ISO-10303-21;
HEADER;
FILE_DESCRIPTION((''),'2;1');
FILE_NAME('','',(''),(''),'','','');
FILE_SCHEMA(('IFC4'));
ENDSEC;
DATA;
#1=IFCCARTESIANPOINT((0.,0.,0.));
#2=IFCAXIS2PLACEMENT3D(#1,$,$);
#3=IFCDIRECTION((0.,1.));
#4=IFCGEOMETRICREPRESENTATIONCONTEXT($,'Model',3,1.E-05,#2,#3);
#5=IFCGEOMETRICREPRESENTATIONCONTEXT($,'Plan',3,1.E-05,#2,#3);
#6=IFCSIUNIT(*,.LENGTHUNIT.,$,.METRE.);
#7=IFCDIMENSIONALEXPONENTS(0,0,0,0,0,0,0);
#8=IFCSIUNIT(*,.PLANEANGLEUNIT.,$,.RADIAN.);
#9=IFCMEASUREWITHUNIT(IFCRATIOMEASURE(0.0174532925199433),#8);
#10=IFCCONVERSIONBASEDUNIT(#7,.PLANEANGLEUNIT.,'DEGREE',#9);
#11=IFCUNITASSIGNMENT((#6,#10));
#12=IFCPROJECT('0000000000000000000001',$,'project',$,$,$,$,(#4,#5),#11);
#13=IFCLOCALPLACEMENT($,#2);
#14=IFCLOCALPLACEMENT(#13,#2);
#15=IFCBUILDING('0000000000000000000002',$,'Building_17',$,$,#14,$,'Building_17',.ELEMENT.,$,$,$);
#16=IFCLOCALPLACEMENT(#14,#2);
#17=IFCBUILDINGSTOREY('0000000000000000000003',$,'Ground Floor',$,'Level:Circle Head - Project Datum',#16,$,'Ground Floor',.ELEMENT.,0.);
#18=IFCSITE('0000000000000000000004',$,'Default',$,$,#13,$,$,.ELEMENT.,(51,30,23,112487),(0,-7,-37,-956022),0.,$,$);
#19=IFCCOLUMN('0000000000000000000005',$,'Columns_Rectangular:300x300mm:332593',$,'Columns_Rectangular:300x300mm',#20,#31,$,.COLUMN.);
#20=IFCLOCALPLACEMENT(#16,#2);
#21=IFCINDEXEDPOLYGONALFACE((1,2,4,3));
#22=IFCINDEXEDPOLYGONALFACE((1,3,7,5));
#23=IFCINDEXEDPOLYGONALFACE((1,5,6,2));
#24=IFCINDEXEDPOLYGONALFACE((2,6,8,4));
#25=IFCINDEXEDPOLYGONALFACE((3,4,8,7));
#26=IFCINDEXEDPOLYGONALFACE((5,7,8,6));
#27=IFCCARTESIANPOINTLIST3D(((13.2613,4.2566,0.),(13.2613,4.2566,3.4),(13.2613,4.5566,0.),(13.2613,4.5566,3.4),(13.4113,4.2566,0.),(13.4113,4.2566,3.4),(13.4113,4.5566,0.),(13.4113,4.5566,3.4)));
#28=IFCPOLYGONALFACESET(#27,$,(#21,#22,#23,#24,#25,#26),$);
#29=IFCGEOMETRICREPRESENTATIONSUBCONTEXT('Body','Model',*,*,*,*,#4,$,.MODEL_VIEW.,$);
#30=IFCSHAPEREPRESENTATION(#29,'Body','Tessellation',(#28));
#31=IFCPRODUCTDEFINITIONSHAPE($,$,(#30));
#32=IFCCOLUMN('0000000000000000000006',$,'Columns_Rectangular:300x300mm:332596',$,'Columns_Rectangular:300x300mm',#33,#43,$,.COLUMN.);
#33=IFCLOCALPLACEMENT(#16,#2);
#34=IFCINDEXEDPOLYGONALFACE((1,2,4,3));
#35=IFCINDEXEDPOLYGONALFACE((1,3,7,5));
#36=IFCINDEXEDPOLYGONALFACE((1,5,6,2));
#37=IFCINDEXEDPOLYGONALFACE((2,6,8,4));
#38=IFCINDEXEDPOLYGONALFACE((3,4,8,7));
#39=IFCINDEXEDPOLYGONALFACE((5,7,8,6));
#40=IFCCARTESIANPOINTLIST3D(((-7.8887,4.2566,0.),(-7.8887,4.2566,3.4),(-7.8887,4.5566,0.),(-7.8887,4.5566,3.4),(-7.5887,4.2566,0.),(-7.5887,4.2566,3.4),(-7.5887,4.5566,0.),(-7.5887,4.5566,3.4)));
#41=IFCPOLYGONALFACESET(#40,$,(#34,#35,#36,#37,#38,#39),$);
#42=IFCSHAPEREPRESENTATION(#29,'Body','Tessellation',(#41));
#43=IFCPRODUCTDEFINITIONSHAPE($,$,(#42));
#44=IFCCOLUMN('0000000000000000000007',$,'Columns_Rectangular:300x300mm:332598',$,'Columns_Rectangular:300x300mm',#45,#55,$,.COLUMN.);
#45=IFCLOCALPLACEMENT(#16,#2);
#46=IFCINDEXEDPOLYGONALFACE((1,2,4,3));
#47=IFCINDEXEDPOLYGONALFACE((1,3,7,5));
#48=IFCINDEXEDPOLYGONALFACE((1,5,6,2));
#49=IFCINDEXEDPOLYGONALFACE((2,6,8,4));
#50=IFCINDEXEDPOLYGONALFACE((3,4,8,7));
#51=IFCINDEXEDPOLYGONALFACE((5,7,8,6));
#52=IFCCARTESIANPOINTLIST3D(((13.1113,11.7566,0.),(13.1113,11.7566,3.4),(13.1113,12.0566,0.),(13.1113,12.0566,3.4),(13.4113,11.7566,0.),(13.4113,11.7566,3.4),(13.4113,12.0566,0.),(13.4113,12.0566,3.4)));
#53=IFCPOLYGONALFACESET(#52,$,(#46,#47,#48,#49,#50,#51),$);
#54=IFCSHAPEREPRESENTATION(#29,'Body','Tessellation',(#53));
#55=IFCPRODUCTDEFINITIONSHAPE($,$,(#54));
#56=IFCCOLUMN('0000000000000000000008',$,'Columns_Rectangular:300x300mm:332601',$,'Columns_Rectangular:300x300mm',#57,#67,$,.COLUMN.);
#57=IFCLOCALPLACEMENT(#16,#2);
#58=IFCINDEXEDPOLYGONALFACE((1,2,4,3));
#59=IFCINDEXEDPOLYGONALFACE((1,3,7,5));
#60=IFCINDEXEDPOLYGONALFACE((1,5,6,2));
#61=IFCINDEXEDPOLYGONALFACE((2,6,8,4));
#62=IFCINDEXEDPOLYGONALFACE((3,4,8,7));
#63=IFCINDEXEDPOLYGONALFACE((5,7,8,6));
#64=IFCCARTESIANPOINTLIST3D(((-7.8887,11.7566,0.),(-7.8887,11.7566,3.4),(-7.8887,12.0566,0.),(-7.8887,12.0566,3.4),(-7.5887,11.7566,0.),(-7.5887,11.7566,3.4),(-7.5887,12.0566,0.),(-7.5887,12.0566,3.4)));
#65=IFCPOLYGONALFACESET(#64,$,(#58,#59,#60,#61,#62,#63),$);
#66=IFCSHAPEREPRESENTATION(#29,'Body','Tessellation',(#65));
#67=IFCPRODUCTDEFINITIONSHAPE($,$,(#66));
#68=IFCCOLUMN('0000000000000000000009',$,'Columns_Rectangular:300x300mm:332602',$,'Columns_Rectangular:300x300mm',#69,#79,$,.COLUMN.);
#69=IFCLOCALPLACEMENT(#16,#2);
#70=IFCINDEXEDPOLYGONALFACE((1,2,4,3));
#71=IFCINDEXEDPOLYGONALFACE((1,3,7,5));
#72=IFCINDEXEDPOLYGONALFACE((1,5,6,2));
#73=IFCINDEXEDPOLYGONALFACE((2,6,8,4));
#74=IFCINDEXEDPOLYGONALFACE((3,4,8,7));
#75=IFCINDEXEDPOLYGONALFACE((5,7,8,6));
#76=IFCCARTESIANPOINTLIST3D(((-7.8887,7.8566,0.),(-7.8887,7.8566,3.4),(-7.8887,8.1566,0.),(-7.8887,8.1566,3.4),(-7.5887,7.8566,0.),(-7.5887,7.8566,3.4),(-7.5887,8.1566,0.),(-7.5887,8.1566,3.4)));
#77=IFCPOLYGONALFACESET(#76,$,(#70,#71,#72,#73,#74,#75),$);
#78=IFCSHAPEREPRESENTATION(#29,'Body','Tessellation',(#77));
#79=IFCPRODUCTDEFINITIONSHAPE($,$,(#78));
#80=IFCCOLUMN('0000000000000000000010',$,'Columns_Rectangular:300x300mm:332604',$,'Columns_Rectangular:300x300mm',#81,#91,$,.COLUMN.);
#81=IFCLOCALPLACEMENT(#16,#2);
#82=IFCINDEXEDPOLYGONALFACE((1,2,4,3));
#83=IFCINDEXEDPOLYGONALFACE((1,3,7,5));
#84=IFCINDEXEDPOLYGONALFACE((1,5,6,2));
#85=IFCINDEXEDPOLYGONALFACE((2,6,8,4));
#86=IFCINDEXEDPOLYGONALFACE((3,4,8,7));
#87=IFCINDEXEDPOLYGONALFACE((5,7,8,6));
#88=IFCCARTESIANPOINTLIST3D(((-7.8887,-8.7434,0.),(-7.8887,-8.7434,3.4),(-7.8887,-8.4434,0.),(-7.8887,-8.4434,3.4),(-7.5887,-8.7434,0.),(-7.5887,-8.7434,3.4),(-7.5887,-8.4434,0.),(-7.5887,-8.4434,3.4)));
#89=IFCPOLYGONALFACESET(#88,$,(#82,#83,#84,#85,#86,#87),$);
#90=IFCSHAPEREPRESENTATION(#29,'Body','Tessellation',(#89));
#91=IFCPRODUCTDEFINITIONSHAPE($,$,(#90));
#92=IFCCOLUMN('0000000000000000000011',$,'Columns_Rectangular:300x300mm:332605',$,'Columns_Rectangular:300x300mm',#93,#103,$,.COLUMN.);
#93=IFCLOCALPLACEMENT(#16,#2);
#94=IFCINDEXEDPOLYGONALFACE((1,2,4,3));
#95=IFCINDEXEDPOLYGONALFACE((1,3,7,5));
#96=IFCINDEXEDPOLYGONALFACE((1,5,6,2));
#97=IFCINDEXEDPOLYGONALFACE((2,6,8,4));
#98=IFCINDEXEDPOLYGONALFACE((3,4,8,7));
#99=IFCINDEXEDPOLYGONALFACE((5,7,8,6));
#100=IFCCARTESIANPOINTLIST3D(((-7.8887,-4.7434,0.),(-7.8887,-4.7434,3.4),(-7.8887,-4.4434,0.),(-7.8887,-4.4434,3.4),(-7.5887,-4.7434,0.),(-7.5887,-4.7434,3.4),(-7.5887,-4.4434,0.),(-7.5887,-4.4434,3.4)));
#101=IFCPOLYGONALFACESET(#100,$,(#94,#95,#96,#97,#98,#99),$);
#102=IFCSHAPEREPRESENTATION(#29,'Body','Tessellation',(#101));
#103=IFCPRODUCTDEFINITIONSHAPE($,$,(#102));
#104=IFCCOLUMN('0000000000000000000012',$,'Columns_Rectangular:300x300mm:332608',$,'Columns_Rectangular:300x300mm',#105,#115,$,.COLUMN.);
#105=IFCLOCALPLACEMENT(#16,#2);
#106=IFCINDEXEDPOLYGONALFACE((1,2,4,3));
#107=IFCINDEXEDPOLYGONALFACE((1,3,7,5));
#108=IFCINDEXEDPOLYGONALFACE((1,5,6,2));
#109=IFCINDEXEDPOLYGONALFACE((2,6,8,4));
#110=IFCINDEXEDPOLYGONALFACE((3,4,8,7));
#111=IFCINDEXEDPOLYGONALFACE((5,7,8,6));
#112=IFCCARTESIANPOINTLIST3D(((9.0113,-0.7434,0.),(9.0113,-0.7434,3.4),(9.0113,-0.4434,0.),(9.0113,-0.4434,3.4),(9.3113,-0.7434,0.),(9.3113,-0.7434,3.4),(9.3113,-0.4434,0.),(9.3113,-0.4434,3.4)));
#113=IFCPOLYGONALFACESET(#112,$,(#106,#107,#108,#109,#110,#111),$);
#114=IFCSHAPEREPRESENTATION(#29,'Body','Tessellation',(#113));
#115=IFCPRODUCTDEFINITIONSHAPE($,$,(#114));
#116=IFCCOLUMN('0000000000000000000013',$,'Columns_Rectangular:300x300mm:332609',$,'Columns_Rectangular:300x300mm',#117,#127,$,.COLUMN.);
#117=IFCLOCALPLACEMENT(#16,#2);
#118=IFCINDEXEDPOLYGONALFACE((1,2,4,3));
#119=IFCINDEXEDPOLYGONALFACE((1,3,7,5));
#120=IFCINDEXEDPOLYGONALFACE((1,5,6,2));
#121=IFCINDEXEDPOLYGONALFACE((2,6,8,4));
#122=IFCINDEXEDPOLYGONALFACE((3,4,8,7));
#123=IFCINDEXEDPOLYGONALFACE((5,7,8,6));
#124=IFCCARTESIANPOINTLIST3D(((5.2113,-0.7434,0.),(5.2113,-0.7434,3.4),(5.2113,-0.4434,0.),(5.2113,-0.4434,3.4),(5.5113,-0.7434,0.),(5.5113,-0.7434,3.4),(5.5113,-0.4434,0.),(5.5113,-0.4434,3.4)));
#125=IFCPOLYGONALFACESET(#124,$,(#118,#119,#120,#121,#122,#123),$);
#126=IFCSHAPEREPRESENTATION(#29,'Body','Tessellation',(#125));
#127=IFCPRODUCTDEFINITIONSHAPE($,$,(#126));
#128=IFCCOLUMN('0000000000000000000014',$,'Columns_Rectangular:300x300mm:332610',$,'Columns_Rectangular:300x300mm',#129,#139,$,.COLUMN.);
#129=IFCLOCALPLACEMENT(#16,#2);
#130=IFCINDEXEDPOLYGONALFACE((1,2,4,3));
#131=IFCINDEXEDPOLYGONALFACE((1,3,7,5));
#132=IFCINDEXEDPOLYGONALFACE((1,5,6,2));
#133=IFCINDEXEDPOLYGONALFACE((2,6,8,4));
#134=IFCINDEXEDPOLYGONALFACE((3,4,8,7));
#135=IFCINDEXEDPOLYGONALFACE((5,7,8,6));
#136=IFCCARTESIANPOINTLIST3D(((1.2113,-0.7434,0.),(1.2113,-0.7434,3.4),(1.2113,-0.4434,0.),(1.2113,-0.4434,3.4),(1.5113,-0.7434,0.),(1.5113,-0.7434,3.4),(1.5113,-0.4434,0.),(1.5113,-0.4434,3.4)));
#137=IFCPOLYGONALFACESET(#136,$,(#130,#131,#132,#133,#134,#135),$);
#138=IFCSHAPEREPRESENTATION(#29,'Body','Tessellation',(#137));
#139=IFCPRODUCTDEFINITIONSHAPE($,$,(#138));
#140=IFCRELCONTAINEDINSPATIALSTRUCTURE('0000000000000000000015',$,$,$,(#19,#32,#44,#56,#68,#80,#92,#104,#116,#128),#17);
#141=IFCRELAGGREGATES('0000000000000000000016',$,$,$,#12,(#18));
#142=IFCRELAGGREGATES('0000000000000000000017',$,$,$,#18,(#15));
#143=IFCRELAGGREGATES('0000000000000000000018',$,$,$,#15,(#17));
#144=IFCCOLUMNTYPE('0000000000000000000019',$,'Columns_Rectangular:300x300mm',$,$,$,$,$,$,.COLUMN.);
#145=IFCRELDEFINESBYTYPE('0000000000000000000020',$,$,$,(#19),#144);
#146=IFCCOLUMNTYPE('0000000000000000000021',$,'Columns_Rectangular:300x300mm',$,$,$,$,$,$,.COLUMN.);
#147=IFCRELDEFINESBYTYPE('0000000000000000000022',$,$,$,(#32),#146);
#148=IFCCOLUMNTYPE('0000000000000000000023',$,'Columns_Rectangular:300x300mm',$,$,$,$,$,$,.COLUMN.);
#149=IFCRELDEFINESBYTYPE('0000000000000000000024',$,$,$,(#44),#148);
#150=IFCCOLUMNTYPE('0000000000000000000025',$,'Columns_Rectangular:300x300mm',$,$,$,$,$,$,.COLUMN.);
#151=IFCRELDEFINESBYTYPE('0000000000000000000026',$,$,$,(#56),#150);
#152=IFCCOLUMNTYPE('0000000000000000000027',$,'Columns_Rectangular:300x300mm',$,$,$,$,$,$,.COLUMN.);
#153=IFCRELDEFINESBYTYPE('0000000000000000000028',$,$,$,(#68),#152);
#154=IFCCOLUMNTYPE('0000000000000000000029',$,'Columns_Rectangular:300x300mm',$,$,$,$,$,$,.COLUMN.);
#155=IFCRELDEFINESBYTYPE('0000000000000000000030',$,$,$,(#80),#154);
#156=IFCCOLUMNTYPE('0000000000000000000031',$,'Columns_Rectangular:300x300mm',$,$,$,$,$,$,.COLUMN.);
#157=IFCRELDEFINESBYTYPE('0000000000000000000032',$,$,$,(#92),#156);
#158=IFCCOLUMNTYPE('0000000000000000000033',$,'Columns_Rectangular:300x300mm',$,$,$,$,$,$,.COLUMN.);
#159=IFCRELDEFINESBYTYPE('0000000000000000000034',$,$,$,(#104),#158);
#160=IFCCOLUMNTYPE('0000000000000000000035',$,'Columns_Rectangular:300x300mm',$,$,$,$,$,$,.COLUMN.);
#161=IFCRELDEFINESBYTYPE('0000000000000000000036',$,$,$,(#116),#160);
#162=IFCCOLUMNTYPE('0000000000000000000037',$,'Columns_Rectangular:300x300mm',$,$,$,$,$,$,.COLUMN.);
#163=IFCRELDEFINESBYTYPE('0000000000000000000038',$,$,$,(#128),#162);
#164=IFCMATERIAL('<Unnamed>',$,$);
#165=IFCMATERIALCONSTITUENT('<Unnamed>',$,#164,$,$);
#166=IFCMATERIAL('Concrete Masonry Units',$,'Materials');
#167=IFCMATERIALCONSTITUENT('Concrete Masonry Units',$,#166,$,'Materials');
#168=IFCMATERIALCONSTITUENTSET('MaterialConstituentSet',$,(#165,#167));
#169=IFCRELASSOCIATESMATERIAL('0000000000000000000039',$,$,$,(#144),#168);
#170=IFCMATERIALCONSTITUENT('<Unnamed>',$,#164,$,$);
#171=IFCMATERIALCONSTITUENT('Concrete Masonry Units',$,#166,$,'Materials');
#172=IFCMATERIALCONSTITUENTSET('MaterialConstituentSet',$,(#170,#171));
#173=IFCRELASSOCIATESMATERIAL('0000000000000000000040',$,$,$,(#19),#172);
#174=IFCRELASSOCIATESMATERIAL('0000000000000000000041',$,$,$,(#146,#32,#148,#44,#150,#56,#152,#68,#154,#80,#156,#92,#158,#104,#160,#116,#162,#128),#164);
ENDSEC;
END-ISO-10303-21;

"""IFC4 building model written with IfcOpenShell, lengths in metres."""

from ifc_helpers import new_model, entity, si_unit, converted_unit, direction, frame, origin, place, context, subcontext, project, spatial, indexed_curve, outline, extrude, source, transform, mapped, material, constituent, constituent_set, type_object, type_shapes, element, save


model = new_model("IFC4")

# Units and contexts
model_context = context("Model", 3, precision=1e-05, world=origin(), true_north=direction((0.0, 1.0)))
plan_context = context("Plan", 3, precision=1e-05, world=origin(), true_north=direction((0.0, 1.0)))
body_context = subcontext(model_context, "Body", "Model", "MODEL_VIEW")
ifc_project = project(units=[si_unit("LENGTHUNIT", "METRE"), converted_unit("PLANEANGLEUNIT", "DEGREE", entity("IfcRatioMeasure", 0.0174532925199433), si_unit("PLANEANGLEUNIT", "RADIAN"), dimensions=[0, 0, 0, 0, 0, 0, 0])], contexts=[model_context, plan_context])

# Site, building, storey
site_placement = place(None, origin())
site = spatial("IfcSite", under=ifc_project, at=site_placement, Name="Default", CompositionType="ELEMENT", RefLatitude=(51, 30, 23, 112487), RefLongitude=(0, -7, -37, -956022), RefElevation=0.0)
building_placement = place(site_placement, origin())
building = spatial("IfcBuilding", under=site, at=building_placement, Name="Building_17", LongName="Building_17", CompositionType="ELEMENT")
storey_placement = place(building_placement, origin())
storey = spatial("IfcBuildingStorey", under=building, at=storey_placement, Name="Ground Floor", ObjectType="Level:Circle Head - Project Datum", LongName="Ground Floor", CompositionType="ELEMENT", Elevation=0.0)

# Columns
ifc_material_1 = material(Name="<Unnamed>")
ifc_constituent_1 = constituent(ifc_material_1, Name="<Unnamed>")
ifc_material_2 = material(Name="Concrete Masonry Units", Category="Materials")
ifc_constituent_2 = constituent(ifc_material_2, Name="Concrete Masonry Units", Category="Materials")
ifc_constituent_set_1 = constituent_set(constituents=[ifc_constituent_1, ifc_constituent_2], Name="MaterialConstituentSet")
ifc_constituent_3 = constituent(ifc_material_1, Name="<Unnamed>")
ifc_constituent_4 = constituent(ifc_material_2, Name="Concrete Masonry Units", Category="Materials")
ifc_constituent_set_2 = constituent_set(constituents=[ifc_constituent_3, ifc_constituent_4], Name="MaterialConstituentSet")
column_type_1 = type_object("IfcColumnType", Name="Columns_Rectangular:300x300mm", PredefinedType="COLUMN", material=ifc_constituent_set_2)
shared_shape_1 = source(origin(), body_context, "Body", "SweptSolid", [
    extrude(outline(indexed_curve([(-0.15, -0.075), (0.15, -0.075), (0.15, 0.075), (-0.15, 0.075), (-0.15, -0.075)], self_intersect=False)), frame((13.3363, 4.4066, 0.0), z_axis=(0.0, 0.0, 1.0), x_axis=(0.0, -1.0, 0.0)), (0.0, 0.0, 1.0), 3.4),
])
type_shapes(column_type_1, [shared_shape_1])
column_1_placement = place(storey_placement, origin())
element("IfcColumn", 1, at=column_1_placement, inside=storey, type_object=column_type_1, material=ifc_constituent_set_1, Name="Columns_Rectangular:300x300mm:332593", ObjectType="Columns_Rectangular:300x300mm", PredefinedType="COLUMN", context=body_context, shape_type="MappedRepresentation", body=[
    mapped(shared_shape_1, transform((0.0, 0.0, 0.0), scale=1.0)),
])
column_type_2 = type_object("IfcColumnType", Name="Columns_Rectangular:300x300mm", PredefinedType="COLUMN", material=ifc_material_1)
shared_shape_2 = source(origin(), body_context, "Body", "SweptSolid", [
    extrude(outline(indexed_curve([(-0.15, -0.15), (0.15, -0.15), (0.15, 0.15), (-0.15, 0.15), (-0.15, -0.15)], self_intersect=False)), frame((-7.7387, 4.4066, 0.0), z_axis=(0.0, 0.0, 1.0), x_axis=(0.0, -1.0, 0.0)), (0.0, 0.0, 1.0), 3.4),
])
type_shapes(column_type_2, [shared_shape_2])
column_2_placement = place(storey_placement, origin())
element("IfcColumn", 2, at=column_2_placement, inside=storey, type_object=column_type_2, material=ifc_material_1, Name="Columns_Rectangular:300x300mm:332596", ObjectType="Columns_Rectangular:300x300mm", PredefinedType="COLUMN", context=body_context, shape_type="MappedRepresentation", body=[
    mapped(shared_shape_2, transform((0.0, 0.0, 0.0), scale=1.0)),
])
column_type_3 = type_object("IfcColumnType", Name="Columns_Rectangular:300x300mm", PredefinedType="COLUMN", material=ifc_material_1)
shared_shape_3 = source(origin(), body_context, "Body", "SweptSolid", [
    extrude(outline(indexed_curve([(-0.15, -0.15), (0.15, -0.15), (0.15, 0.15), (-0.15, 0.15), (-0.15, -0.15)], self_intersect=False)), frame((13.2613, 11.9066, 0.0), z_axis=(0.0, 0.0, 1.0), x_axis=(0.0, -1.0, 0.0)), (0.0, 0.0, 1.0), 3.4),
])
type_shapes(column_type_3, [shared_shape_3])
column_3_placement = place(storey_placement, origin())
element("IfcColumn", 3, at=column_3_placement, inside=storey, type_object=column_type_3, material=ifc_material_1, Name="Columns_Rectangular:300x300mm:332598", ObjectType="Columns_Rectangular:300x300mm", PredefinedType="COLUMN", context=body_context, shape_type="MappedRepresentation", body=[
    mapped(shared_shape_3, transform((0.0, 0.0, 0.0), scale=1.0)),
])
column_type_4 = type_object("IfcColumnType", Name="Columns_Rectangular:300x300mm", PredefinedType="COLUMN", material=ifc_material_1)
shared_shape_4 = source(origin(), body_context, "Body", "SweptSolid", [
    extrude(outline(indexed_curve([(-0.15, -0.15), (0.15, -0.15), (0.15, 0.15), (-0.15, 0.15), (-0.15, -0.15)], self_intersect=False)), frame((-7.7387, 11.9066, 0.0), z_axis=(0.0, 0.0, 1.0), x_axis=(0.0, -1.0, 0.0)), (0.0, 0.0, 1.0), 3.4),
])
type_shapes(column_type_4, [shared_shape_4])
column_4_placement = place(storey_placement, origin())
element("IfcColumn", 4, at=column_4_placement, inside=storey, type_object=column_type_4, material=ifc_material_1, Name="Columns_Rectangular:300x300mm:332601", ObjectType="Columns_Rectangular:300x300mm", PredefinedType="COLUMN", context=body_context, shape_type="MappedRepresentation", body=[
    mapped(shared_shape_4, transform((0.0, 0.0, 0.0), scale=1.0)),
])
column_type_5 = type_object("IfcColumnType", Name="Columns_Rectangular:300x300mm", PredefinedType="COLUMN", material=ifc_material_1)
shared_shape_5 = source(origin(), body_context, "Body", "SweptSolid", [
    extrude(outline(indexed_curve([(-0.15, -0.15), (0.15, -0.15), (0.15, 0.15), (-0.15, 0.15), (-0.15, -0.15)], self_intersect=False)), frame((-7.7387, 8.0066, 0.0), z_axis=(0.0, 0.0, 1.0), x_axis=(0.0, -1.0, 0.0)), (0.0, 0.0, 1.0), 3.4),
])
type_shapes(column_type_5, [shared_shape_5])
column_5_placement = place(storey_placement, origin())
element("IfcColumn", 5, at=column_5_placement, inside=storey, type_object=column_type_5, material=ifc_material_1, Name="Columns_Rectangular:300x300mm:332602", ObjectType="Columns_Rectangular:300x300mm", PredefinedType="COLUMN", context=body_context, shape_type="MappedRepresentation", body=[
    mapped(shared_shape_5, transform((0.0, 0.0, 0.0), scale=1.0)),
])
column_type_6 = type_object("IfcColumnType", Name="Columns_Rectangular:300x300mm", PredefinedType="COLUMN", material=ifc_material_1)
shared_shape_6 = source(origin(), body_context, "Body", "SweptSolid", [
    extrude(outline(indexed_curve([(-0.15, -0.15), (0.15, -0.15), (0.15, 0.15), (-0.15, 0.15), (-0.15, -0.15)], self_intersect=False)), frame((-7.7387, -8.5934, 0.0), z_axis=(0.0, 0.0, 1.0), x_axis=(0.0, -1.0, 0.0)), (0.0, 0.0, 1.0), 3.4),
])
type_shapes(column_type_6, [shared_shape_6])
column_6_placement = place(storey_placement, origin())
element("IfcColumn", 6, at=column_6_placement, inside=storey, type_object=column_type_6, material=ifc_material_1, Name="Columns_Rectangular:300x300mm:332604", ObjectType="Columns_Rectangular:300x300mm", PredefinedType="COLUMN", context=body_context, shape_type="MappedRepresentation", body=[
    mapped(shared_shape_6, transform((0.0, 0.0, 0.0), scale=1.0)),
])
column_type_7 = type_object("IfcColumnType", Name="Columns_Rectangular:300x300mm", PredefinedType="COLUMN", material=ifc_material_1)
shared_shape_7 = source(origin(), body_context, "Body", "SweptSolid", [
    extrude(outline(indexed_curve([(-0.15, -0.15), (0.15, -0.15), (0.15, 0.15), (-0.15, 0.15), (-0.15, -0.15)], self_intersect=False)), frame((-7.7387, -4.5934, 0.0), z_axis=(0.0, 0.0, 1.0), x_axis=(0.0, -1.0, 0.0)), (0.0, 0.0, 1.0), 3.4),
])
type_shapes(column_type_7, [shared_shape_7])
column_7_placement = place(storey_placement, origin())
element("IfcColumn", 7, at=column_7_placement, inside=storey, type_object=column_type_7, material=ifc_material_1, Name="Columns_Rectangular:300x300mm:332605", ObjectType="Columns_Rectangular:300x300mm", PredefinedType="COLUMN", context=body_context, shape_type="MappedRepresentation", body=[
    mapped(shared_shape_7, transform((0.0, 0.0, 0.0), scale=1.0)),
])
column_type_8 = type_object("IfcColumnType", Name="Columns_Rectangular:300x300mm", PredefinedType="COLUMN", material=ifc_material_1)
shared_shape_8 = source(origin(), body_context, "Body", "SweptSolid", [
    extrude(outline(indexed_curve([(-0.15, -0.15), (0.15, -0.15), (0.15, 0.15), (-0.15, 0.15), (-0.15, -0.15)], self_intersect=False)), frame((9.1613, -0.5934, 0.0), z_axis=(0.0, 0.0, 1.0), x_axis=(0.0, -1.0, 0.0)), (0.0, 0.0, 1.0), 3.4),
])
type_shapes(column_type_8, [shared_shape_8])
column_8_placement = place(storey_placement, origin())
element("IfcColumn", 8, at=column_8_placement, inside=storey, type_object=column_type_8, material=ifc_material_1, Name="Columns_Rectangular:300x300mm:332608", ObjectType="Columns_Rectangular:300x300mm", PredefinedType="COLUMN", context=body_context, shape_type="MappedRepresentation", body=[
    mapped(shared_shape_8, transform((0.0, 0.0, 0.0), scale=1.0)),
])
column_type_9 = type_object("IfcColumnType", Name="Columns_Rectangular:300x300mm", PredefinedType="COLUMN", material=ifc_material_1)
shared_shape_9 = source(origin(), body_context, "Body", "SweptSolid", [
    extrude(outline(indexed_curve([(-0.15, -0.15), (0.15, -0.15), (0.15, 0.15), (-0.15, 0.15), (-0.15, -0.15)], self_intersect=False)), frame((5.3613, -0.5934, 0.0), z_axis=(0.0, 0.0, 1.0), x_axis=(0.0, -1.0, 0.0)), (0.0, 0.0, 1.0), 3.4),
])
type_shapes(column_type_9, [shared_shape_9])
column_9_placement = place(storey_placement, origin())
element("IfcColumn", 9, at=column_9_placement, inside=storey, type_object=column_type_9, material=ifc_material_1, Name="Columns_Rectangular:300x300mm:332609", ObjectType="Columns_Rectangular:300x300mm", PredefinedType="COLUMN", context=body_context, shape_type="MappedRepresentation", body=[
    mapped(shared_shape_9, transform((0.0, 0.0, 0.0), scale=1.0)),
])
column_type_10 = type_object("IfcColumnType", Name="Columns_Rectangular:300x300mm", PredefinedType="COLUMN", material=ifc_material_1)
shared_shape_10 = source(origin(), body_context, "Body", "SweptSolid", [
    extrude(outline(indexed_curve([(-0.15, -0.15), (0.15, -0.15), (0.15, 0.15), (-0.15, 0.15), (-0.15, -0.15)], self_intersect=False)), frame((1.3613, -0.5934, 0.0), z_axis=(0.0, 0.0, 1.0), x_axis=(0.0, -1.0, 0.0)), (0.0, 0.0, 1.0), 3.4),
])
type_shapes(column_type_10, [shared_shape_10])
column_10_placement = place(storey_placement, origin())
element("IfcColumn", 10, at=column_10_placement, inside=storey, type_object=column_type_10, material=ifc_material_1, Name="Columns_Rectangular:300x300mm:332610", ObjectType="Columns_Rectangular:300x300mm", PredefinedType="COLUMN", context=body_context, shape_type="MappedRepresentation", body=[
    mapped(shared_shape_10, transform((0.0, 0.0, 0.0), scale=1.0)),
])

save(model, "model.ifc")
